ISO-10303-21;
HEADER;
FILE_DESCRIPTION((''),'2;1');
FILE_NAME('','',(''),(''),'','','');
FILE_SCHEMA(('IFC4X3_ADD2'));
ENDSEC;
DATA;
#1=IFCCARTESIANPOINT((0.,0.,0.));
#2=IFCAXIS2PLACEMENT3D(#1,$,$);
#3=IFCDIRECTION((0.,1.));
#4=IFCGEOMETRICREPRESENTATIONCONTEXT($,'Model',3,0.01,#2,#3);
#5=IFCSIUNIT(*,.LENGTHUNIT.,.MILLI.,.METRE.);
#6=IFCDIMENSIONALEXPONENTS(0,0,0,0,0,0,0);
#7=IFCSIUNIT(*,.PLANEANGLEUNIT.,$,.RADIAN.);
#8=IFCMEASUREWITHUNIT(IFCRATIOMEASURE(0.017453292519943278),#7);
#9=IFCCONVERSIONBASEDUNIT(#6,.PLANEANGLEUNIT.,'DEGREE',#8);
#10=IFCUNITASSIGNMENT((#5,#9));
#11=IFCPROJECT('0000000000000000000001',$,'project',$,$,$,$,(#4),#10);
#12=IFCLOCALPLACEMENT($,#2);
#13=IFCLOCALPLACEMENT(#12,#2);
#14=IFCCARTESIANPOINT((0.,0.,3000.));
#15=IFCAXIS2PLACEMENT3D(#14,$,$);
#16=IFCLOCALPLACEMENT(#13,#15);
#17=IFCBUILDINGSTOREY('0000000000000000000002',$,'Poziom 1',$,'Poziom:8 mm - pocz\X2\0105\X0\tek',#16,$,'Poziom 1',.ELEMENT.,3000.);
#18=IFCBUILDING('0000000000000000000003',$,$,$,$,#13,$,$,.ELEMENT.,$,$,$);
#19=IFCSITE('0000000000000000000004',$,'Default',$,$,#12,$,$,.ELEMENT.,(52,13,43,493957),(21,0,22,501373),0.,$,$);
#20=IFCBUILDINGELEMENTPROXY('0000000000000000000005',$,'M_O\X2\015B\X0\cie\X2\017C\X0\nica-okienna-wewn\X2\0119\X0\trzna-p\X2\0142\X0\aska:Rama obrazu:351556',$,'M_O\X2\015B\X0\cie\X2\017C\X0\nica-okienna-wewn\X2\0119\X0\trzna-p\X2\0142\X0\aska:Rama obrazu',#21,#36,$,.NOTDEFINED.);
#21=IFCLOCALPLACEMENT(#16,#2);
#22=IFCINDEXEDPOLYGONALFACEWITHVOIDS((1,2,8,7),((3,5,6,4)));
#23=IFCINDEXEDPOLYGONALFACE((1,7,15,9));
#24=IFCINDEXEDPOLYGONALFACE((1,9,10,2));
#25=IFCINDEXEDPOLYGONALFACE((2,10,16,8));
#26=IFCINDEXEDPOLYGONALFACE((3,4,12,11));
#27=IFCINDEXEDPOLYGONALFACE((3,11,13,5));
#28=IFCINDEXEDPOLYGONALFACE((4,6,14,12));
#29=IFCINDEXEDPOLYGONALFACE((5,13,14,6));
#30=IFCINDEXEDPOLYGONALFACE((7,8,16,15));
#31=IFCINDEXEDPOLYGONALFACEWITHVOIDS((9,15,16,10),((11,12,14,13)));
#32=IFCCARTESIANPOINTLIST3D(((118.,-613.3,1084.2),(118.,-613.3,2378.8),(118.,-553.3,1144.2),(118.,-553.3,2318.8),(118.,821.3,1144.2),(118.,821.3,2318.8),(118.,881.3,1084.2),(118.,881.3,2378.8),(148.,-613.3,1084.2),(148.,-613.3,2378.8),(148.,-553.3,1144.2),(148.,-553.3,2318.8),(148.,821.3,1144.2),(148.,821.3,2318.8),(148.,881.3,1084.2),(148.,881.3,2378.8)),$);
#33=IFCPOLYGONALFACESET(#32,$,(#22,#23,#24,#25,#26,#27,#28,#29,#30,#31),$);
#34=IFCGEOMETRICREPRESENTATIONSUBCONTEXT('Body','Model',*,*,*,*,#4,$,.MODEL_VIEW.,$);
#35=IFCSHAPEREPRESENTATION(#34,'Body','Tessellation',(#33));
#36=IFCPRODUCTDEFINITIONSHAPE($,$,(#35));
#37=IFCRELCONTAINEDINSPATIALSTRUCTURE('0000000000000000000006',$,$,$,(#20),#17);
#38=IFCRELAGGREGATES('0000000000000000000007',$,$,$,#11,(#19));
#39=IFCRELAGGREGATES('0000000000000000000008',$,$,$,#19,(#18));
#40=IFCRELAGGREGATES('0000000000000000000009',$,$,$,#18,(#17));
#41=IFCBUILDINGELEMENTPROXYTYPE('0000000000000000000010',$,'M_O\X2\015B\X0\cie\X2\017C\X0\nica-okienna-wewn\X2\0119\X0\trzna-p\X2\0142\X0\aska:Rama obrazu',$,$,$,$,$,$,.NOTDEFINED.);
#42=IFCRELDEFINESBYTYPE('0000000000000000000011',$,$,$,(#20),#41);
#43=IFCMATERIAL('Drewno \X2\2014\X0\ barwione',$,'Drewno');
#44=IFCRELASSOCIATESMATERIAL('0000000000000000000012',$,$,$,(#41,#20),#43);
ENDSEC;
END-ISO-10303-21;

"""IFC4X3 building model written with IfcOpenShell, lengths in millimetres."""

from ifc_helpers import new_model, entity, si_unit, converted_unit, direction, frame, origin, place, context, subcontext, project, spatial, polyline, outline, extrude, source, transform, mapped, material, type_object, type_shapes, element, save


model = new_model("IFC4X3")

# Units and contexts
model_context = context("Model", 3, precision=0.01, world=origin(), true_north=direction((0.0, 1.0)))
body_context = subcontext(model_context, "Body", "Model", "MODEL_VIEW")
ifc_project = project(units=[si_unit("LENGTHUNIT", "METRE", prefix="MILLI"), converted_unit("PLANEANGLEUNIT", "DEGREE", entity("IfcRatioMeasure", 0.017453292519943278), si_unit("PLANEANGLEUNIT", "RADIAN"), dimensions=[0, 0, 0, 0, 0, 0, 0])], contexts=[model_context])

# Site, building, storey
site_placement = place(None, origin())
site = spatial("IfcSite", under=ifc_project, at=site_placement, Name="Default", CompositionType="ELEMENT", RefLatitude=(52, 13, 43, 493957), RefLongitude=(21, 0, 22, 501373), RefElevation=0.0)
building_placement = place(site_placement, origin())
building = spatial("IfcBuilding", under=site, at=building_placement, CompositionType="ELEMENT")
storey_placement = place(building_placement, frame((0.0, 0.0, 3000.0)))
storey = spatial("IfcBuildingStorey", under=building, at=storey_placement, Name="Poziom 1", ObjectType="Poziom:8 mm - początek", LongName="Poziom 1", CompositionType="ELEMENT", Elevation=3000.0)

# Building element proxy
ifc_material_1 = material(Name="Drewno — barwione", Category="Drewno")
building_element_proxy_type_1 = type_object("IfcBuildingElementProxyType", Name="M_Ościeżnica-okienna-wewnętrzna-płaska:Rama obrazu", PredefinedType="NOTDEFINED", material=ifc_material_1)
shared_shape_1 = source(origin(), body_context, "Body", "SweptSolid", [
    extrude(outline(polyline([(-747.3, -647.3), (747.3, -647.3), (747.3, 647.3), (-747.3, 647.3), (-747.3, -647.3)]), holes=[polyline([(-687.3, -587.3), (-687.3, 587.3), (687.3, 587.3), (687.3, -587.3), (-687.3, -587.3)])]), frame((0.0, -600.0, 0.0), z_axis=(0.0, 0.0, 1.0), x_axis=(-1.0, 0.0, 0.0)), (0.0, 0.0, 1.0), 30.0),
])
type_shapes(building_element_proxy_type_1, [shared_shape_1])
proxy_1_placement = place(storey_placement, frame((118.0, 134.0, 2331.5), z_axis=(1.0, 0.0, 0.0), x_axis=(0.0, 1.0, 0.0)))
element("IfcBuildingElementProxy", 1, at=proxy_1_placement, inside=storey, type_object=building_element_proxy_type_1, material=ifc_material_1, Name="M_Ościeżnica-okienna-wewnętrzna-płaska:Rama obrazu:351556", ObjectType="M_Ościeżnica-okienna-wewnętrzna-płaska:Rama obrazu", PredefinedType="NOTDEFINED", context=body_context, shape_type="MappedRepresentation", body=[
    mapped(shared_shape_1, transform((0.0, 0.0, 0.0), scale=1.0)),
])

save(model, "model.ifc")
